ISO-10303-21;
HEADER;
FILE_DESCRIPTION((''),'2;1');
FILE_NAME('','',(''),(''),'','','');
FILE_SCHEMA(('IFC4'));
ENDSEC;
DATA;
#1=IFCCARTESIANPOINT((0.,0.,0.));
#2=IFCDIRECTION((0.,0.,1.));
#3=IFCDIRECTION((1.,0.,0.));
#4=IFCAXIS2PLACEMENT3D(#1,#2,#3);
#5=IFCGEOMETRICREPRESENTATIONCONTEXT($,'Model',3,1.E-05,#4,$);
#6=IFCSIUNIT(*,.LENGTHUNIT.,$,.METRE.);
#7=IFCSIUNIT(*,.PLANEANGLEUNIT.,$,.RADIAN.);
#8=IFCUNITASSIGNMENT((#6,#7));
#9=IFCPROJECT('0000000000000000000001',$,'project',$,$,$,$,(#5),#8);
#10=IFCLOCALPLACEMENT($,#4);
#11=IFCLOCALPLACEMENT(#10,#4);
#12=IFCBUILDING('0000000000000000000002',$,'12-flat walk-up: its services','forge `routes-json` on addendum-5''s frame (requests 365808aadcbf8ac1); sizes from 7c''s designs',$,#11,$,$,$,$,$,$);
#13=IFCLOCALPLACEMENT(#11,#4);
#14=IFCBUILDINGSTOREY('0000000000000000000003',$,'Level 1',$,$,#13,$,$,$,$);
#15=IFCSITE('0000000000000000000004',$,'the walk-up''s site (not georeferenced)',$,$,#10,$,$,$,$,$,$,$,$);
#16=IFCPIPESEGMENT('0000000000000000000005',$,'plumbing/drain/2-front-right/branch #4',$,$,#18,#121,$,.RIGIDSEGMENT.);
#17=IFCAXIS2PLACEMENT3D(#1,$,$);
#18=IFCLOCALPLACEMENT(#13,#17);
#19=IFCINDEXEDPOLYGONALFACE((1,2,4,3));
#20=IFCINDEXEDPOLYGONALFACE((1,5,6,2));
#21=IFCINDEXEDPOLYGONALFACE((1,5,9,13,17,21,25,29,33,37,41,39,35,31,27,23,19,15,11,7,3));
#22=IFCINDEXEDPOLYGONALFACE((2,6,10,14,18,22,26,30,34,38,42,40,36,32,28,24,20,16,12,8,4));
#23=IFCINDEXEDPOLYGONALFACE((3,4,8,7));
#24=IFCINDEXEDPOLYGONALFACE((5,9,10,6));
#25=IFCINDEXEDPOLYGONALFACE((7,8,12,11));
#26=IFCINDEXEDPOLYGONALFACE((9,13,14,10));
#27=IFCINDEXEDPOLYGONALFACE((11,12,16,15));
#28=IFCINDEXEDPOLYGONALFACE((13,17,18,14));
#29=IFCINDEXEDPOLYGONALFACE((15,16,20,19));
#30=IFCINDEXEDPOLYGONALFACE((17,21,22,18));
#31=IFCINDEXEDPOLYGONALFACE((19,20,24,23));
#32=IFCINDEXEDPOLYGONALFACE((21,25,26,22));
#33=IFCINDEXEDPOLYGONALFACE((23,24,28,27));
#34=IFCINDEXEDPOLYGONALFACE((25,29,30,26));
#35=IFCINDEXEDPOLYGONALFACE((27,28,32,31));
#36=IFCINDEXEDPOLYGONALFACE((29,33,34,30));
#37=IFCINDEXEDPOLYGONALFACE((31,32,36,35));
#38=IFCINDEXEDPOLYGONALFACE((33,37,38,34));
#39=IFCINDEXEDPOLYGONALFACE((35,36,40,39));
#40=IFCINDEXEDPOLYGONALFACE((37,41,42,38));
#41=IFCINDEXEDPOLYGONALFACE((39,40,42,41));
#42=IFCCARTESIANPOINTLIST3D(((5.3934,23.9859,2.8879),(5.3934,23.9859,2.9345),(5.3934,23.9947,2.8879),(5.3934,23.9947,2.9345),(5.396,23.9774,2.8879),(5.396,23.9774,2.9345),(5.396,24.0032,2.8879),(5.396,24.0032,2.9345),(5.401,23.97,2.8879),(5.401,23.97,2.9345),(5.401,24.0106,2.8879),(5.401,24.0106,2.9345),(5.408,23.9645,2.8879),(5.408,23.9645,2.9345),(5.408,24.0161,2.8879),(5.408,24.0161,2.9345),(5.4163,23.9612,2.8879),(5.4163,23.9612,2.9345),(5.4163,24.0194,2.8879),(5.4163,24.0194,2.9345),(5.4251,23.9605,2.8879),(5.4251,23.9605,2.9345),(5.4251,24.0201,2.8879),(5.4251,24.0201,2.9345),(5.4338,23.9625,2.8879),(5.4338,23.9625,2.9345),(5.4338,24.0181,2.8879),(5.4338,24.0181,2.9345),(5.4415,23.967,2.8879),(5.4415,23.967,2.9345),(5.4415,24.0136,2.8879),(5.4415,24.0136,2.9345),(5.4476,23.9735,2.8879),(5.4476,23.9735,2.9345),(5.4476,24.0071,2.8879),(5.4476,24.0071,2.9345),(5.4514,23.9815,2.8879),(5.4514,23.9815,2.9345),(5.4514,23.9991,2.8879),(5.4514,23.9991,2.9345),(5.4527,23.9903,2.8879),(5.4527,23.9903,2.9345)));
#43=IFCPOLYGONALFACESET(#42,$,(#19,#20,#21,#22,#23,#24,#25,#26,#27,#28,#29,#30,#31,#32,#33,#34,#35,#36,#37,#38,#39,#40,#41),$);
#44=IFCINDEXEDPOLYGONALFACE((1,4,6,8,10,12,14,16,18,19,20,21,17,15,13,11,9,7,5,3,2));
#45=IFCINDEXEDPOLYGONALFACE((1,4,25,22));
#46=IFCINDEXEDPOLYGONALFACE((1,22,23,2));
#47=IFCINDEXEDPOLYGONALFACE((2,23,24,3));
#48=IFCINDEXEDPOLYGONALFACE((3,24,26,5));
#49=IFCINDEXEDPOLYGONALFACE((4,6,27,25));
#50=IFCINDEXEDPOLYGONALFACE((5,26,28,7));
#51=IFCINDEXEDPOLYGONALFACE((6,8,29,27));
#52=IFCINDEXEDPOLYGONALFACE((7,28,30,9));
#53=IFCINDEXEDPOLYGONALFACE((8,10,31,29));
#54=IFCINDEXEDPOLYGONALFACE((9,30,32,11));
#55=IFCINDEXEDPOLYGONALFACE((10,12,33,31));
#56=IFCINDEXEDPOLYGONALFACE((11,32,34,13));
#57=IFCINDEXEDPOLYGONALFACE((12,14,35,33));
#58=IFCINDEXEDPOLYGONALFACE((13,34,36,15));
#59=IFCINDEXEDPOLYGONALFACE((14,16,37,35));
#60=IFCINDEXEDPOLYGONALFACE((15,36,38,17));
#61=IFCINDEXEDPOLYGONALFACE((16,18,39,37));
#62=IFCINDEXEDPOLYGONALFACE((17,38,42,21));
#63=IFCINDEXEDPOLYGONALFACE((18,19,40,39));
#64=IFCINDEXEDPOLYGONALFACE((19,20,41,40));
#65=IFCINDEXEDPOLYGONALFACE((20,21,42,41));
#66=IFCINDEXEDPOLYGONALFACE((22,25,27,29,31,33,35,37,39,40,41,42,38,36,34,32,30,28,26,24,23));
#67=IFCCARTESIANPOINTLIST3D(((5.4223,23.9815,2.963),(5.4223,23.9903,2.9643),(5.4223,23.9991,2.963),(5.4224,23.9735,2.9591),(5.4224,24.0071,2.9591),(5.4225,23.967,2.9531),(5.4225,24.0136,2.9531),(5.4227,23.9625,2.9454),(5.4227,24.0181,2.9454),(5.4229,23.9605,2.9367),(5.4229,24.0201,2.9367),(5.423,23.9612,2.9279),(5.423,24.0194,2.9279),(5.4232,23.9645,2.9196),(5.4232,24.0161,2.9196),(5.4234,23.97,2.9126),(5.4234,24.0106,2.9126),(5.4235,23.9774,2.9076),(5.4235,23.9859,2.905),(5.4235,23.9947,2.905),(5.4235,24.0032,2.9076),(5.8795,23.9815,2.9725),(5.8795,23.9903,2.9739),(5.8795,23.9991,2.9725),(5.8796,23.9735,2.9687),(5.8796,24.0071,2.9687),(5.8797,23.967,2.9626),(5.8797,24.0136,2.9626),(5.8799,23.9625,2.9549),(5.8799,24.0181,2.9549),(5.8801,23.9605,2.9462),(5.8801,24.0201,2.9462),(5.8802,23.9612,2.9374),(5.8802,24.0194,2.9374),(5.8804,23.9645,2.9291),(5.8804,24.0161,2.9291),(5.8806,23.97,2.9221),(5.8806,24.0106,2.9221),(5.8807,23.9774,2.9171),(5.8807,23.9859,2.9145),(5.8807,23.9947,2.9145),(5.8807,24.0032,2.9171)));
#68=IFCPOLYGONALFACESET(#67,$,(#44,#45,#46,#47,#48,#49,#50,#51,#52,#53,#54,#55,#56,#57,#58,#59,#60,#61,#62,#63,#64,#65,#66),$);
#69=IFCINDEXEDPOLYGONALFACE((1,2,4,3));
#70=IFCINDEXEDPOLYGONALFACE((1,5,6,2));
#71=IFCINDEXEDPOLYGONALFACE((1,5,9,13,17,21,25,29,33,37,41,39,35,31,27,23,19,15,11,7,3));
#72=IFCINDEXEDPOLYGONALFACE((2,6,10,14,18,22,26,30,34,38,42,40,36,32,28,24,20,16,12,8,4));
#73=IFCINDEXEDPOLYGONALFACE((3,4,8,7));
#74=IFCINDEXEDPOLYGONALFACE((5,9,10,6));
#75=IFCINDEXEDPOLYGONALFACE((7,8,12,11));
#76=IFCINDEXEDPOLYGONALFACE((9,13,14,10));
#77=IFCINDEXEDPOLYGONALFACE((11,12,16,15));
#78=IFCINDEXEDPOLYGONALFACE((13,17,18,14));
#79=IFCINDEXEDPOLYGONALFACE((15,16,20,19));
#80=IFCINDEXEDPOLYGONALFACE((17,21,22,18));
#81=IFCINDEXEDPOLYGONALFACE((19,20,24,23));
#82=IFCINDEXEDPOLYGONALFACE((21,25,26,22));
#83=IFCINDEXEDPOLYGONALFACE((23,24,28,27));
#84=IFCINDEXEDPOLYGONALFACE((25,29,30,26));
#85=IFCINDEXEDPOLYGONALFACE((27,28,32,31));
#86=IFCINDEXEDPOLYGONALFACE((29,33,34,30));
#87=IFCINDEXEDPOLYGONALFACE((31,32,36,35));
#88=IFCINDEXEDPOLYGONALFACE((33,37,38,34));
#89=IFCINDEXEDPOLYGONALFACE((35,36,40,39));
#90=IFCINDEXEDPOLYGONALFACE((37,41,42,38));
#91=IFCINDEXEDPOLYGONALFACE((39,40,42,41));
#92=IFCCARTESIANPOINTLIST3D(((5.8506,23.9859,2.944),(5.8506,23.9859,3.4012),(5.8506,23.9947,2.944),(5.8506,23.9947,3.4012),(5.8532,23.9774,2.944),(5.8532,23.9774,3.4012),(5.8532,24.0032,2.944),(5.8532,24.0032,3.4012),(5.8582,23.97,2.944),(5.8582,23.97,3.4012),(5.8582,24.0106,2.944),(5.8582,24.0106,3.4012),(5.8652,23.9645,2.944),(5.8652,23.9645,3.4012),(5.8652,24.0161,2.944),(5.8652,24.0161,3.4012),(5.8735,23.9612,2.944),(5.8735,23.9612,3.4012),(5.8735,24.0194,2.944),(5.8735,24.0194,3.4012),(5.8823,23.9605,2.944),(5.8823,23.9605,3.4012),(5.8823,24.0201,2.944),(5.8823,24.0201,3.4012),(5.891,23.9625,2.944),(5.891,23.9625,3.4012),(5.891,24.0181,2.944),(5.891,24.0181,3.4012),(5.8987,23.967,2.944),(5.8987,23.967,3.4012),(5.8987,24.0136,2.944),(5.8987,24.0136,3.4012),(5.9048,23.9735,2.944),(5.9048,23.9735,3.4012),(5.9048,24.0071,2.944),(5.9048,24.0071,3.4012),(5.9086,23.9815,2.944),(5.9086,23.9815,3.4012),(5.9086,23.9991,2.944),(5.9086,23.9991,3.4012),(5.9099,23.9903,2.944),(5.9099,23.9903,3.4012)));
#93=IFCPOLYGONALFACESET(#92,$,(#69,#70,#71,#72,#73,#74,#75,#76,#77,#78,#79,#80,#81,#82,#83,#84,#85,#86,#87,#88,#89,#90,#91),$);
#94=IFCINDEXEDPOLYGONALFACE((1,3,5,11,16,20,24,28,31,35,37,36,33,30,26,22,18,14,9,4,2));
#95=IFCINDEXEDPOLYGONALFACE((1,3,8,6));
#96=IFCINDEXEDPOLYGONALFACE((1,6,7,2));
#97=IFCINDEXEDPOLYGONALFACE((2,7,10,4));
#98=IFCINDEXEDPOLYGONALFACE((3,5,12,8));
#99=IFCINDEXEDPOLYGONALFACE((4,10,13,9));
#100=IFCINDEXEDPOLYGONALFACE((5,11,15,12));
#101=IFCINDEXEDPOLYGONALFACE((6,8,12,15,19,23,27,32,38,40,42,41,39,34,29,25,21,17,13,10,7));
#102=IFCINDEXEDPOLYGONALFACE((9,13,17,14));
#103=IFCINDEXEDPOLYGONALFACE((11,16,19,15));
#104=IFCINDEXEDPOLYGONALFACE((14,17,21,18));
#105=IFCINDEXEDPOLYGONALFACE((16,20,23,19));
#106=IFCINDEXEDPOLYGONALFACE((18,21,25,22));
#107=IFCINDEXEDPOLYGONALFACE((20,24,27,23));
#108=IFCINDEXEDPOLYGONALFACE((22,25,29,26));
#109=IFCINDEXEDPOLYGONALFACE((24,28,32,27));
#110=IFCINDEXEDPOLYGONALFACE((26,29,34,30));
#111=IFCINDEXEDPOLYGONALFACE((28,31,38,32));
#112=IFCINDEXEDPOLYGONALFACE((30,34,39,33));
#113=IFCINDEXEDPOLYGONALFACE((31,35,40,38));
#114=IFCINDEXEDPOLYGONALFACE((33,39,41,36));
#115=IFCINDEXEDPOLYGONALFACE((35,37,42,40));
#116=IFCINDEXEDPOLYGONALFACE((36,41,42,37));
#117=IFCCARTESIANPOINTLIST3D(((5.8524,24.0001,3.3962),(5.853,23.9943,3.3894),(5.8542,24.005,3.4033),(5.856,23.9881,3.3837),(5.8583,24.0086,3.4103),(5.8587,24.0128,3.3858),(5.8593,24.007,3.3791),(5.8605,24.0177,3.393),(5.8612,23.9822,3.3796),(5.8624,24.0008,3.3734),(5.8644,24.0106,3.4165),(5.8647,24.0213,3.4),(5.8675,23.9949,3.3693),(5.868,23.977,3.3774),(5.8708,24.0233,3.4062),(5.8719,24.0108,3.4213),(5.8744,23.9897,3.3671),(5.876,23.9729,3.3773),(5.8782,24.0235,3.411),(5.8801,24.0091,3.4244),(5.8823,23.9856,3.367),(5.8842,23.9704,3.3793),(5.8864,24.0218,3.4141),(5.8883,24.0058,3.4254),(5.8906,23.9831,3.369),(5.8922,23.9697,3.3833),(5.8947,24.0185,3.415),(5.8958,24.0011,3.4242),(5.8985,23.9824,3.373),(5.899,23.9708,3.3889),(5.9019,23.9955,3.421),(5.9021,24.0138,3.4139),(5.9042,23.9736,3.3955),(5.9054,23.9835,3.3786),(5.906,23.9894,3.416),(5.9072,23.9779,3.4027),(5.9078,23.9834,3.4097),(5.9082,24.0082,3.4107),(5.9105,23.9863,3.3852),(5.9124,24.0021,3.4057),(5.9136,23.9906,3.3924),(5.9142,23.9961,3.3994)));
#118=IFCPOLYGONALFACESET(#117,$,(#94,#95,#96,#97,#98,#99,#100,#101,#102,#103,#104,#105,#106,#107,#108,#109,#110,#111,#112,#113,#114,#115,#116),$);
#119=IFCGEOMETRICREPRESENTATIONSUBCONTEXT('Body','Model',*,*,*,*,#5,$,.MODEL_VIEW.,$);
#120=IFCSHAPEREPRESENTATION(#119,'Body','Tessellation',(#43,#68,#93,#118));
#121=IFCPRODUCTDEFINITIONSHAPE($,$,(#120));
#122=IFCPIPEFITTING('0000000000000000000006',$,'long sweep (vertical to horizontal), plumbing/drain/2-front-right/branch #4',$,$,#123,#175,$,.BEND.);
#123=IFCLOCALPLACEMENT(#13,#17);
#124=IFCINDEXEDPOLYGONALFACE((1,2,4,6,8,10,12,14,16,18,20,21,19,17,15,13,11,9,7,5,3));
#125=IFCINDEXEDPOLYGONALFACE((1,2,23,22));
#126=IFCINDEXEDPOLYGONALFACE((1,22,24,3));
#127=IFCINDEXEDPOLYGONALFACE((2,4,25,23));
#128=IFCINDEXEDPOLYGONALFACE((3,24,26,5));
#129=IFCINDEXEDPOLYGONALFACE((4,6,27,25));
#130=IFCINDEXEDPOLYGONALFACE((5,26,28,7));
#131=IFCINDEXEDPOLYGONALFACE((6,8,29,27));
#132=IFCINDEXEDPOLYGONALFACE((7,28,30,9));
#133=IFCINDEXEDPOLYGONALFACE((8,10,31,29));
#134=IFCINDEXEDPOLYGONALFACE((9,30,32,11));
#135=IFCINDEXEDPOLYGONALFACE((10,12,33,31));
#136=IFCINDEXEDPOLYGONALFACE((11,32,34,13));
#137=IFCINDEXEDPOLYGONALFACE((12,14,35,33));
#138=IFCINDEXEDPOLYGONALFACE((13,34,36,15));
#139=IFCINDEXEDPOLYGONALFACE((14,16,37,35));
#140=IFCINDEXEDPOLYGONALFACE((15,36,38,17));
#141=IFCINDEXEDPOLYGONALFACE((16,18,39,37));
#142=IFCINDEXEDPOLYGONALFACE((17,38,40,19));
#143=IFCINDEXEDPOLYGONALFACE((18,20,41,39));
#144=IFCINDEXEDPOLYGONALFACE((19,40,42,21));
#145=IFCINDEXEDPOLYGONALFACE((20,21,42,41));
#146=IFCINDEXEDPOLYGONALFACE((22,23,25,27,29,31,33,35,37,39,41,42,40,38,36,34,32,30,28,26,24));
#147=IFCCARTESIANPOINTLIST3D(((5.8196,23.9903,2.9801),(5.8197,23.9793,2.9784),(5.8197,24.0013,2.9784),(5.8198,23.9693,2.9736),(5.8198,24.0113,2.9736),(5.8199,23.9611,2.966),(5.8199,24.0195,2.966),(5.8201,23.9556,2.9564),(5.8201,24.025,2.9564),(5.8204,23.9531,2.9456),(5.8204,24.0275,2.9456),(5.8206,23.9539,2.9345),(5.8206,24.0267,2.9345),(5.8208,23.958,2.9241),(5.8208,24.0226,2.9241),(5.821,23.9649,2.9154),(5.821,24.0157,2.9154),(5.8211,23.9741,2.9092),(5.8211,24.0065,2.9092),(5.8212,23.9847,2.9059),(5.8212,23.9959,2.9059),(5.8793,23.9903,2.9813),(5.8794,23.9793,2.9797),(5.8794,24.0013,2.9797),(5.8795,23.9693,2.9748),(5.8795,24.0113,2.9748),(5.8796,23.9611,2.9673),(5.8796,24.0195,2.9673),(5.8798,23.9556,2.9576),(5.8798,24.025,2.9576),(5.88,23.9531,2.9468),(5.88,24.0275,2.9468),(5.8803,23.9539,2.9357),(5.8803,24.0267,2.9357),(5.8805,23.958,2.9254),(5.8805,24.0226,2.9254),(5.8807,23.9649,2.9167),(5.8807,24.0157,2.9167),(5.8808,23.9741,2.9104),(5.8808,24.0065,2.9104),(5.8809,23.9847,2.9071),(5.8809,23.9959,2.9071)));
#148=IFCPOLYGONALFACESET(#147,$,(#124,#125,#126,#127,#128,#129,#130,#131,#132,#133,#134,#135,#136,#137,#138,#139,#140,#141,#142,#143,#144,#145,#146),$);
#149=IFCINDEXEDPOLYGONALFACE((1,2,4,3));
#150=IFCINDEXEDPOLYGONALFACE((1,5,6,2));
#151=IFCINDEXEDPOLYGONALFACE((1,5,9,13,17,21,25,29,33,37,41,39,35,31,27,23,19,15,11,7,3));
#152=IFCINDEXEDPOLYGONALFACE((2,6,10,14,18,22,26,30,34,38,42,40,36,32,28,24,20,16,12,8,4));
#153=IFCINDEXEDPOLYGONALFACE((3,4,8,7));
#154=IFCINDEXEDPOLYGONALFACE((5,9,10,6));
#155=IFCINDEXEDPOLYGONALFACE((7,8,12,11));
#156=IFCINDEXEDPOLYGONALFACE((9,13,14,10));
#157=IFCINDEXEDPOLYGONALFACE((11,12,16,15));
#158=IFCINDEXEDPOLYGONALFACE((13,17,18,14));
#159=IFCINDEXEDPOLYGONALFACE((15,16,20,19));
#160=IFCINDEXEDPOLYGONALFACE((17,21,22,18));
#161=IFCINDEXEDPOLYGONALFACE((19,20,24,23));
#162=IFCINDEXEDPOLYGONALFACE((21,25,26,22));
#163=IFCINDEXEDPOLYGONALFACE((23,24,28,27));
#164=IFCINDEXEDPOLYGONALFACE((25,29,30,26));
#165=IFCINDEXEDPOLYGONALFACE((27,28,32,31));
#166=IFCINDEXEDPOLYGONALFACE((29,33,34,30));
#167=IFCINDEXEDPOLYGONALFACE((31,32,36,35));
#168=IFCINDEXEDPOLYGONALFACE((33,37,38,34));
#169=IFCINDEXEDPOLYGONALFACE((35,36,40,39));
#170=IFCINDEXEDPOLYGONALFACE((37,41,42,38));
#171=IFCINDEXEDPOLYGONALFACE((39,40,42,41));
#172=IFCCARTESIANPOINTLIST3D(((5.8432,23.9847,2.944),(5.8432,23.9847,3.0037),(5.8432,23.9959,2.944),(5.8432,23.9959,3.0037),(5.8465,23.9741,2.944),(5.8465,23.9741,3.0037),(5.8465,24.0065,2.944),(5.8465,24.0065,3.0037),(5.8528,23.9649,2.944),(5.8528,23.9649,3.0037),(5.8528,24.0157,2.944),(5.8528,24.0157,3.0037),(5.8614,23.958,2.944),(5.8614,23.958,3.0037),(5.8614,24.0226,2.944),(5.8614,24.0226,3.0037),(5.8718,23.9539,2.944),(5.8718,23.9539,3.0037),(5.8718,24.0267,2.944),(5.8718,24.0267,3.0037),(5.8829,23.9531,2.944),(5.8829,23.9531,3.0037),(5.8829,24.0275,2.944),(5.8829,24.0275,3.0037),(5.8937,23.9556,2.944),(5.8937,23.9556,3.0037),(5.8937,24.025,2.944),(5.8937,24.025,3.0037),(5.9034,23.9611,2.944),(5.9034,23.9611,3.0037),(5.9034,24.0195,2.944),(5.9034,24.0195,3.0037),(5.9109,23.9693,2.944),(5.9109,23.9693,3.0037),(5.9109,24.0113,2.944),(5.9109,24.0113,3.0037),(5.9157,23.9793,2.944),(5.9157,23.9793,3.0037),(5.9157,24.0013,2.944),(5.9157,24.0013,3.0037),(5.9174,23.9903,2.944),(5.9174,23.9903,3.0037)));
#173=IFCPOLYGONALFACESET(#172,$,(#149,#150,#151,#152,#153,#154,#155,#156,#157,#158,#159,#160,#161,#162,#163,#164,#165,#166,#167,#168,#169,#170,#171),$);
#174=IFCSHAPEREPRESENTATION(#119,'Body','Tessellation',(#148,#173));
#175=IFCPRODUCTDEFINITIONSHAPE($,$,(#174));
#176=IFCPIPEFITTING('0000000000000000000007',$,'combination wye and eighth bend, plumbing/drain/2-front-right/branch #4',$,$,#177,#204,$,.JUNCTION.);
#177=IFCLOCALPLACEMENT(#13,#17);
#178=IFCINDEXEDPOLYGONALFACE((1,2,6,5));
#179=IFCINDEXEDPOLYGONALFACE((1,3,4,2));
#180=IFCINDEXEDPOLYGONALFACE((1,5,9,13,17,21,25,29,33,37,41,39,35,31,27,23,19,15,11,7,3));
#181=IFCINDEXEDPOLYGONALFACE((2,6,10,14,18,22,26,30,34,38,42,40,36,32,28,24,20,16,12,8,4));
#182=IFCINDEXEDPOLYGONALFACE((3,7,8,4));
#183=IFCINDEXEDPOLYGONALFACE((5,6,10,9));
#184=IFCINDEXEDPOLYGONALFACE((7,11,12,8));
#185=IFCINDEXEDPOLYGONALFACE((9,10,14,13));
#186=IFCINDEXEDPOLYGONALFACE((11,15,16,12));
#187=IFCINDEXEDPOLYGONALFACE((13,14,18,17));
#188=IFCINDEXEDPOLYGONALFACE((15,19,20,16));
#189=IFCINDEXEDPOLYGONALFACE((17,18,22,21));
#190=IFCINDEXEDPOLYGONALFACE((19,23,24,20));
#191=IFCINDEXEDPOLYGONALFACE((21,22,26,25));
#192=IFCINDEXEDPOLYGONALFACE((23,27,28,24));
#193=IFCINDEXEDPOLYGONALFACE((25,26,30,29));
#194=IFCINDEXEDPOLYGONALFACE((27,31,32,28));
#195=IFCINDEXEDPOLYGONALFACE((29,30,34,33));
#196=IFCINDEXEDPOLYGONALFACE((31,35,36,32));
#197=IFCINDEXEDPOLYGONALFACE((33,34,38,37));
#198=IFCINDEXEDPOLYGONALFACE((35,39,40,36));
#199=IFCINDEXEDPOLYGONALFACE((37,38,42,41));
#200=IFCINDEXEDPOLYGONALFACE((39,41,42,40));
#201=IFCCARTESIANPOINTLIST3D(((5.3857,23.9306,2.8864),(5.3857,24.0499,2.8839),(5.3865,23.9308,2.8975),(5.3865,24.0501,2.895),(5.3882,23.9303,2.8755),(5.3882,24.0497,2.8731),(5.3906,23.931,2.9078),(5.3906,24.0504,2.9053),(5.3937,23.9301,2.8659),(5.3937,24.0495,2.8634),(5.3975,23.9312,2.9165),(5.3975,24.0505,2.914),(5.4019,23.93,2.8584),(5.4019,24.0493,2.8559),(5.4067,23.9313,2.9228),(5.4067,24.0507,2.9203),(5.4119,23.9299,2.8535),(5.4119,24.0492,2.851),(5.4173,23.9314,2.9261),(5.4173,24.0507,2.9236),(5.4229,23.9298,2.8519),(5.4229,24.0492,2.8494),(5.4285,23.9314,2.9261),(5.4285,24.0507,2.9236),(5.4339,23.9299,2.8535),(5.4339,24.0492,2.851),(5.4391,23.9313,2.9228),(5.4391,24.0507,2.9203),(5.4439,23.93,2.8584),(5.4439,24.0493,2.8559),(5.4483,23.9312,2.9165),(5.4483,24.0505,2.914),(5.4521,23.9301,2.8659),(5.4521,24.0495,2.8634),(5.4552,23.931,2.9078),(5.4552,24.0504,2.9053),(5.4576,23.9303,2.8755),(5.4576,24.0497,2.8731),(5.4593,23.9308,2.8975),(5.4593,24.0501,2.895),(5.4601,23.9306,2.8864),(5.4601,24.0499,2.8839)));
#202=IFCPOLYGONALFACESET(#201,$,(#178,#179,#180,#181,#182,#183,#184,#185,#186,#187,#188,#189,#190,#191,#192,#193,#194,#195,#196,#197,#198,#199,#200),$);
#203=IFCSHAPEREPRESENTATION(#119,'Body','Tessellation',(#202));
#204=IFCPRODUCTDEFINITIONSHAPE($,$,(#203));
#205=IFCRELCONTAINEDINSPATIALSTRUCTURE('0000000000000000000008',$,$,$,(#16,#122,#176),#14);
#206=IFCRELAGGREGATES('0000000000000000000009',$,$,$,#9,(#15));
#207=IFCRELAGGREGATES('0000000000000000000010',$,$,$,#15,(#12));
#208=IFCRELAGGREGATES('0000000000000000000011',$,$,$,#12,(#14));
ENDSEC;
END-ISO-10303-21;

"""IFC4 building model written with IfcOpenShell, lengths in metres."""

from ifc_helpers import new_model, entity, si_unit, frame, origin_with_axes, place, context, subcontext, project, spatial, element, save


model = new_model("IFC4")

# Units and contexts
model_context = context("Model", 3, precision=1e-05, world=origin_with_axes())
body_context = subcontext(model_context, "Body", "Model", "MODEL_VIEW")
ifc_project = project(units=[si_unit("LENGTHUNIT", "METRE"), si_unit("PLANEANGLEUNIT", "RADIAN")], contexts=[model_context])

# Site, building, storey
site_placement = place(None, origin_with_axes())
site = spatial("IfcSite", under=ifc_project, at=site_placement, Name="the walk-up's site (not georeferenced)")
building_placement = place(site_placement, origin_with_axes())
building = spatial("IfcBuilding", under=site, at=building_placement, Name="12-flat walk-up: its services", Description="forge `routes-json` on addendum-5's frame (requests 365808aadcbf8ac1); sizes from 7c's designs")
storey_placement = place(building_placement, origin_with_axes())
storey = spatial("IfcBuildingStorey", under=building, at=storey_placement, Name="Level 1")

# Pipe segment
pipe_segment_1_placement = place(storey_placement, frame((5.4229, 23.9903, 2.8879), z_axis=(0.0, 0.0, 1.0), x_axis=(1.0, 0.0, 0.0)))
element("IfcPipeSegment", 1, at=pipe_segment_1_placement, inside=storey, Name="plumbing/drain/2-front-right/branch #4", PredefinedType="RIGIDSEGMENT", context=body_context, shape_type="AdvancedSweptSolid", body=[
    entity("IfcSweptDiskSolid", entity("IfcPolyline", [entity("IfcCartesianPoint", [0.0, 0.0, 0.0]), entity("IfcCartesianPoint", [0.0, 0.0, 0.0466])]), 0.0298),
    entity("IfcSweptDiskSolid", entity("IfcPolyline", [entity("IfcCartesianPoint", [0.0, 0.0, 0.0466]), entity("IfcCartesianPoint", [0.4572, 0.0, 0.0561])]), 0.0298),
    entity("IfcSweptDiskSolid", entity("IfcPolyline", [entity("IfcCartesianPoint", [0.4572, 0.0, 0.0561]), entity("IfcCartesianPoint", [0.4572, 0.0, 0.5133])]), 0.0298),
    entity("IfcSweptDiskSolid", entity("IfcPolyline", [entity("IfcCartesianPoint", [0.4572, 0.0, 0.5133]), entity("IfcCartesianPoint", [0.4635, 0.0127, 0.503])]), 0.0298),
])

# Pipe fittings
pipe_fitting_1_placement = place(storey_placement, frame((5.8204, 23.9903, 2.9428), z_axis=(0.0, 0.0, 1.0), x_axis=(1.0, 0.0, 0.0)))
element("IfcPipeFitting", 2, at=pipe_fitting_1_placement, inside=storey, Name="long sweep (vertical to horizontal), plumbing/drain/2-front-right/branch #4", PredefinedType="BEND", context=body_context, shape_type="AdvancedSweptSolid", body=[
    entity("IfcSweptDiskSolid", entity("IfcPolyline", [entity("IfcCartesianPoint", [0.0, 0.0, 0.0]), entity("IfcCartesianPoint", [0.0597, 0.0, 0.0012])]), 0.0373),
    entity("IfcSweptDiskSolid", entity("IfcPolyline", [entity("IfcCartesianPoint", [0.0597, 0.0, 0.0012]), entity("IfcCartesianPoint", [0.0597, 0.0, 0.0609])]), 0.0373),
])
pipe_fitting_2_placement = place(storey_placement, frame((5.4229, 24.05, 2.8867), z_axis=(0.0, 0.0, 1.0), x_axis=(1.0, 0.0, 0.0)))
element("IfcPipeFitting", 3, at=pipe_fitting_2_placement, inside=storey, Name="combination wye and eighth bend, plumbing/drain/2-front-right/branch #4", PredefinedType="JUNCTION", context=body_context, shape_type="AdvancedSweptSolid", body=[
    entity("IfcSweptDiskSolid", entity("IfcPolyline", [entity("IfcCartesianPoint", [0.0, 0.0, 0.0]), entity("IfcCartesianPoint", [0.0, -0.1194, 0.0025])]), 0.0373),
])

save(model, "model.ifc")
